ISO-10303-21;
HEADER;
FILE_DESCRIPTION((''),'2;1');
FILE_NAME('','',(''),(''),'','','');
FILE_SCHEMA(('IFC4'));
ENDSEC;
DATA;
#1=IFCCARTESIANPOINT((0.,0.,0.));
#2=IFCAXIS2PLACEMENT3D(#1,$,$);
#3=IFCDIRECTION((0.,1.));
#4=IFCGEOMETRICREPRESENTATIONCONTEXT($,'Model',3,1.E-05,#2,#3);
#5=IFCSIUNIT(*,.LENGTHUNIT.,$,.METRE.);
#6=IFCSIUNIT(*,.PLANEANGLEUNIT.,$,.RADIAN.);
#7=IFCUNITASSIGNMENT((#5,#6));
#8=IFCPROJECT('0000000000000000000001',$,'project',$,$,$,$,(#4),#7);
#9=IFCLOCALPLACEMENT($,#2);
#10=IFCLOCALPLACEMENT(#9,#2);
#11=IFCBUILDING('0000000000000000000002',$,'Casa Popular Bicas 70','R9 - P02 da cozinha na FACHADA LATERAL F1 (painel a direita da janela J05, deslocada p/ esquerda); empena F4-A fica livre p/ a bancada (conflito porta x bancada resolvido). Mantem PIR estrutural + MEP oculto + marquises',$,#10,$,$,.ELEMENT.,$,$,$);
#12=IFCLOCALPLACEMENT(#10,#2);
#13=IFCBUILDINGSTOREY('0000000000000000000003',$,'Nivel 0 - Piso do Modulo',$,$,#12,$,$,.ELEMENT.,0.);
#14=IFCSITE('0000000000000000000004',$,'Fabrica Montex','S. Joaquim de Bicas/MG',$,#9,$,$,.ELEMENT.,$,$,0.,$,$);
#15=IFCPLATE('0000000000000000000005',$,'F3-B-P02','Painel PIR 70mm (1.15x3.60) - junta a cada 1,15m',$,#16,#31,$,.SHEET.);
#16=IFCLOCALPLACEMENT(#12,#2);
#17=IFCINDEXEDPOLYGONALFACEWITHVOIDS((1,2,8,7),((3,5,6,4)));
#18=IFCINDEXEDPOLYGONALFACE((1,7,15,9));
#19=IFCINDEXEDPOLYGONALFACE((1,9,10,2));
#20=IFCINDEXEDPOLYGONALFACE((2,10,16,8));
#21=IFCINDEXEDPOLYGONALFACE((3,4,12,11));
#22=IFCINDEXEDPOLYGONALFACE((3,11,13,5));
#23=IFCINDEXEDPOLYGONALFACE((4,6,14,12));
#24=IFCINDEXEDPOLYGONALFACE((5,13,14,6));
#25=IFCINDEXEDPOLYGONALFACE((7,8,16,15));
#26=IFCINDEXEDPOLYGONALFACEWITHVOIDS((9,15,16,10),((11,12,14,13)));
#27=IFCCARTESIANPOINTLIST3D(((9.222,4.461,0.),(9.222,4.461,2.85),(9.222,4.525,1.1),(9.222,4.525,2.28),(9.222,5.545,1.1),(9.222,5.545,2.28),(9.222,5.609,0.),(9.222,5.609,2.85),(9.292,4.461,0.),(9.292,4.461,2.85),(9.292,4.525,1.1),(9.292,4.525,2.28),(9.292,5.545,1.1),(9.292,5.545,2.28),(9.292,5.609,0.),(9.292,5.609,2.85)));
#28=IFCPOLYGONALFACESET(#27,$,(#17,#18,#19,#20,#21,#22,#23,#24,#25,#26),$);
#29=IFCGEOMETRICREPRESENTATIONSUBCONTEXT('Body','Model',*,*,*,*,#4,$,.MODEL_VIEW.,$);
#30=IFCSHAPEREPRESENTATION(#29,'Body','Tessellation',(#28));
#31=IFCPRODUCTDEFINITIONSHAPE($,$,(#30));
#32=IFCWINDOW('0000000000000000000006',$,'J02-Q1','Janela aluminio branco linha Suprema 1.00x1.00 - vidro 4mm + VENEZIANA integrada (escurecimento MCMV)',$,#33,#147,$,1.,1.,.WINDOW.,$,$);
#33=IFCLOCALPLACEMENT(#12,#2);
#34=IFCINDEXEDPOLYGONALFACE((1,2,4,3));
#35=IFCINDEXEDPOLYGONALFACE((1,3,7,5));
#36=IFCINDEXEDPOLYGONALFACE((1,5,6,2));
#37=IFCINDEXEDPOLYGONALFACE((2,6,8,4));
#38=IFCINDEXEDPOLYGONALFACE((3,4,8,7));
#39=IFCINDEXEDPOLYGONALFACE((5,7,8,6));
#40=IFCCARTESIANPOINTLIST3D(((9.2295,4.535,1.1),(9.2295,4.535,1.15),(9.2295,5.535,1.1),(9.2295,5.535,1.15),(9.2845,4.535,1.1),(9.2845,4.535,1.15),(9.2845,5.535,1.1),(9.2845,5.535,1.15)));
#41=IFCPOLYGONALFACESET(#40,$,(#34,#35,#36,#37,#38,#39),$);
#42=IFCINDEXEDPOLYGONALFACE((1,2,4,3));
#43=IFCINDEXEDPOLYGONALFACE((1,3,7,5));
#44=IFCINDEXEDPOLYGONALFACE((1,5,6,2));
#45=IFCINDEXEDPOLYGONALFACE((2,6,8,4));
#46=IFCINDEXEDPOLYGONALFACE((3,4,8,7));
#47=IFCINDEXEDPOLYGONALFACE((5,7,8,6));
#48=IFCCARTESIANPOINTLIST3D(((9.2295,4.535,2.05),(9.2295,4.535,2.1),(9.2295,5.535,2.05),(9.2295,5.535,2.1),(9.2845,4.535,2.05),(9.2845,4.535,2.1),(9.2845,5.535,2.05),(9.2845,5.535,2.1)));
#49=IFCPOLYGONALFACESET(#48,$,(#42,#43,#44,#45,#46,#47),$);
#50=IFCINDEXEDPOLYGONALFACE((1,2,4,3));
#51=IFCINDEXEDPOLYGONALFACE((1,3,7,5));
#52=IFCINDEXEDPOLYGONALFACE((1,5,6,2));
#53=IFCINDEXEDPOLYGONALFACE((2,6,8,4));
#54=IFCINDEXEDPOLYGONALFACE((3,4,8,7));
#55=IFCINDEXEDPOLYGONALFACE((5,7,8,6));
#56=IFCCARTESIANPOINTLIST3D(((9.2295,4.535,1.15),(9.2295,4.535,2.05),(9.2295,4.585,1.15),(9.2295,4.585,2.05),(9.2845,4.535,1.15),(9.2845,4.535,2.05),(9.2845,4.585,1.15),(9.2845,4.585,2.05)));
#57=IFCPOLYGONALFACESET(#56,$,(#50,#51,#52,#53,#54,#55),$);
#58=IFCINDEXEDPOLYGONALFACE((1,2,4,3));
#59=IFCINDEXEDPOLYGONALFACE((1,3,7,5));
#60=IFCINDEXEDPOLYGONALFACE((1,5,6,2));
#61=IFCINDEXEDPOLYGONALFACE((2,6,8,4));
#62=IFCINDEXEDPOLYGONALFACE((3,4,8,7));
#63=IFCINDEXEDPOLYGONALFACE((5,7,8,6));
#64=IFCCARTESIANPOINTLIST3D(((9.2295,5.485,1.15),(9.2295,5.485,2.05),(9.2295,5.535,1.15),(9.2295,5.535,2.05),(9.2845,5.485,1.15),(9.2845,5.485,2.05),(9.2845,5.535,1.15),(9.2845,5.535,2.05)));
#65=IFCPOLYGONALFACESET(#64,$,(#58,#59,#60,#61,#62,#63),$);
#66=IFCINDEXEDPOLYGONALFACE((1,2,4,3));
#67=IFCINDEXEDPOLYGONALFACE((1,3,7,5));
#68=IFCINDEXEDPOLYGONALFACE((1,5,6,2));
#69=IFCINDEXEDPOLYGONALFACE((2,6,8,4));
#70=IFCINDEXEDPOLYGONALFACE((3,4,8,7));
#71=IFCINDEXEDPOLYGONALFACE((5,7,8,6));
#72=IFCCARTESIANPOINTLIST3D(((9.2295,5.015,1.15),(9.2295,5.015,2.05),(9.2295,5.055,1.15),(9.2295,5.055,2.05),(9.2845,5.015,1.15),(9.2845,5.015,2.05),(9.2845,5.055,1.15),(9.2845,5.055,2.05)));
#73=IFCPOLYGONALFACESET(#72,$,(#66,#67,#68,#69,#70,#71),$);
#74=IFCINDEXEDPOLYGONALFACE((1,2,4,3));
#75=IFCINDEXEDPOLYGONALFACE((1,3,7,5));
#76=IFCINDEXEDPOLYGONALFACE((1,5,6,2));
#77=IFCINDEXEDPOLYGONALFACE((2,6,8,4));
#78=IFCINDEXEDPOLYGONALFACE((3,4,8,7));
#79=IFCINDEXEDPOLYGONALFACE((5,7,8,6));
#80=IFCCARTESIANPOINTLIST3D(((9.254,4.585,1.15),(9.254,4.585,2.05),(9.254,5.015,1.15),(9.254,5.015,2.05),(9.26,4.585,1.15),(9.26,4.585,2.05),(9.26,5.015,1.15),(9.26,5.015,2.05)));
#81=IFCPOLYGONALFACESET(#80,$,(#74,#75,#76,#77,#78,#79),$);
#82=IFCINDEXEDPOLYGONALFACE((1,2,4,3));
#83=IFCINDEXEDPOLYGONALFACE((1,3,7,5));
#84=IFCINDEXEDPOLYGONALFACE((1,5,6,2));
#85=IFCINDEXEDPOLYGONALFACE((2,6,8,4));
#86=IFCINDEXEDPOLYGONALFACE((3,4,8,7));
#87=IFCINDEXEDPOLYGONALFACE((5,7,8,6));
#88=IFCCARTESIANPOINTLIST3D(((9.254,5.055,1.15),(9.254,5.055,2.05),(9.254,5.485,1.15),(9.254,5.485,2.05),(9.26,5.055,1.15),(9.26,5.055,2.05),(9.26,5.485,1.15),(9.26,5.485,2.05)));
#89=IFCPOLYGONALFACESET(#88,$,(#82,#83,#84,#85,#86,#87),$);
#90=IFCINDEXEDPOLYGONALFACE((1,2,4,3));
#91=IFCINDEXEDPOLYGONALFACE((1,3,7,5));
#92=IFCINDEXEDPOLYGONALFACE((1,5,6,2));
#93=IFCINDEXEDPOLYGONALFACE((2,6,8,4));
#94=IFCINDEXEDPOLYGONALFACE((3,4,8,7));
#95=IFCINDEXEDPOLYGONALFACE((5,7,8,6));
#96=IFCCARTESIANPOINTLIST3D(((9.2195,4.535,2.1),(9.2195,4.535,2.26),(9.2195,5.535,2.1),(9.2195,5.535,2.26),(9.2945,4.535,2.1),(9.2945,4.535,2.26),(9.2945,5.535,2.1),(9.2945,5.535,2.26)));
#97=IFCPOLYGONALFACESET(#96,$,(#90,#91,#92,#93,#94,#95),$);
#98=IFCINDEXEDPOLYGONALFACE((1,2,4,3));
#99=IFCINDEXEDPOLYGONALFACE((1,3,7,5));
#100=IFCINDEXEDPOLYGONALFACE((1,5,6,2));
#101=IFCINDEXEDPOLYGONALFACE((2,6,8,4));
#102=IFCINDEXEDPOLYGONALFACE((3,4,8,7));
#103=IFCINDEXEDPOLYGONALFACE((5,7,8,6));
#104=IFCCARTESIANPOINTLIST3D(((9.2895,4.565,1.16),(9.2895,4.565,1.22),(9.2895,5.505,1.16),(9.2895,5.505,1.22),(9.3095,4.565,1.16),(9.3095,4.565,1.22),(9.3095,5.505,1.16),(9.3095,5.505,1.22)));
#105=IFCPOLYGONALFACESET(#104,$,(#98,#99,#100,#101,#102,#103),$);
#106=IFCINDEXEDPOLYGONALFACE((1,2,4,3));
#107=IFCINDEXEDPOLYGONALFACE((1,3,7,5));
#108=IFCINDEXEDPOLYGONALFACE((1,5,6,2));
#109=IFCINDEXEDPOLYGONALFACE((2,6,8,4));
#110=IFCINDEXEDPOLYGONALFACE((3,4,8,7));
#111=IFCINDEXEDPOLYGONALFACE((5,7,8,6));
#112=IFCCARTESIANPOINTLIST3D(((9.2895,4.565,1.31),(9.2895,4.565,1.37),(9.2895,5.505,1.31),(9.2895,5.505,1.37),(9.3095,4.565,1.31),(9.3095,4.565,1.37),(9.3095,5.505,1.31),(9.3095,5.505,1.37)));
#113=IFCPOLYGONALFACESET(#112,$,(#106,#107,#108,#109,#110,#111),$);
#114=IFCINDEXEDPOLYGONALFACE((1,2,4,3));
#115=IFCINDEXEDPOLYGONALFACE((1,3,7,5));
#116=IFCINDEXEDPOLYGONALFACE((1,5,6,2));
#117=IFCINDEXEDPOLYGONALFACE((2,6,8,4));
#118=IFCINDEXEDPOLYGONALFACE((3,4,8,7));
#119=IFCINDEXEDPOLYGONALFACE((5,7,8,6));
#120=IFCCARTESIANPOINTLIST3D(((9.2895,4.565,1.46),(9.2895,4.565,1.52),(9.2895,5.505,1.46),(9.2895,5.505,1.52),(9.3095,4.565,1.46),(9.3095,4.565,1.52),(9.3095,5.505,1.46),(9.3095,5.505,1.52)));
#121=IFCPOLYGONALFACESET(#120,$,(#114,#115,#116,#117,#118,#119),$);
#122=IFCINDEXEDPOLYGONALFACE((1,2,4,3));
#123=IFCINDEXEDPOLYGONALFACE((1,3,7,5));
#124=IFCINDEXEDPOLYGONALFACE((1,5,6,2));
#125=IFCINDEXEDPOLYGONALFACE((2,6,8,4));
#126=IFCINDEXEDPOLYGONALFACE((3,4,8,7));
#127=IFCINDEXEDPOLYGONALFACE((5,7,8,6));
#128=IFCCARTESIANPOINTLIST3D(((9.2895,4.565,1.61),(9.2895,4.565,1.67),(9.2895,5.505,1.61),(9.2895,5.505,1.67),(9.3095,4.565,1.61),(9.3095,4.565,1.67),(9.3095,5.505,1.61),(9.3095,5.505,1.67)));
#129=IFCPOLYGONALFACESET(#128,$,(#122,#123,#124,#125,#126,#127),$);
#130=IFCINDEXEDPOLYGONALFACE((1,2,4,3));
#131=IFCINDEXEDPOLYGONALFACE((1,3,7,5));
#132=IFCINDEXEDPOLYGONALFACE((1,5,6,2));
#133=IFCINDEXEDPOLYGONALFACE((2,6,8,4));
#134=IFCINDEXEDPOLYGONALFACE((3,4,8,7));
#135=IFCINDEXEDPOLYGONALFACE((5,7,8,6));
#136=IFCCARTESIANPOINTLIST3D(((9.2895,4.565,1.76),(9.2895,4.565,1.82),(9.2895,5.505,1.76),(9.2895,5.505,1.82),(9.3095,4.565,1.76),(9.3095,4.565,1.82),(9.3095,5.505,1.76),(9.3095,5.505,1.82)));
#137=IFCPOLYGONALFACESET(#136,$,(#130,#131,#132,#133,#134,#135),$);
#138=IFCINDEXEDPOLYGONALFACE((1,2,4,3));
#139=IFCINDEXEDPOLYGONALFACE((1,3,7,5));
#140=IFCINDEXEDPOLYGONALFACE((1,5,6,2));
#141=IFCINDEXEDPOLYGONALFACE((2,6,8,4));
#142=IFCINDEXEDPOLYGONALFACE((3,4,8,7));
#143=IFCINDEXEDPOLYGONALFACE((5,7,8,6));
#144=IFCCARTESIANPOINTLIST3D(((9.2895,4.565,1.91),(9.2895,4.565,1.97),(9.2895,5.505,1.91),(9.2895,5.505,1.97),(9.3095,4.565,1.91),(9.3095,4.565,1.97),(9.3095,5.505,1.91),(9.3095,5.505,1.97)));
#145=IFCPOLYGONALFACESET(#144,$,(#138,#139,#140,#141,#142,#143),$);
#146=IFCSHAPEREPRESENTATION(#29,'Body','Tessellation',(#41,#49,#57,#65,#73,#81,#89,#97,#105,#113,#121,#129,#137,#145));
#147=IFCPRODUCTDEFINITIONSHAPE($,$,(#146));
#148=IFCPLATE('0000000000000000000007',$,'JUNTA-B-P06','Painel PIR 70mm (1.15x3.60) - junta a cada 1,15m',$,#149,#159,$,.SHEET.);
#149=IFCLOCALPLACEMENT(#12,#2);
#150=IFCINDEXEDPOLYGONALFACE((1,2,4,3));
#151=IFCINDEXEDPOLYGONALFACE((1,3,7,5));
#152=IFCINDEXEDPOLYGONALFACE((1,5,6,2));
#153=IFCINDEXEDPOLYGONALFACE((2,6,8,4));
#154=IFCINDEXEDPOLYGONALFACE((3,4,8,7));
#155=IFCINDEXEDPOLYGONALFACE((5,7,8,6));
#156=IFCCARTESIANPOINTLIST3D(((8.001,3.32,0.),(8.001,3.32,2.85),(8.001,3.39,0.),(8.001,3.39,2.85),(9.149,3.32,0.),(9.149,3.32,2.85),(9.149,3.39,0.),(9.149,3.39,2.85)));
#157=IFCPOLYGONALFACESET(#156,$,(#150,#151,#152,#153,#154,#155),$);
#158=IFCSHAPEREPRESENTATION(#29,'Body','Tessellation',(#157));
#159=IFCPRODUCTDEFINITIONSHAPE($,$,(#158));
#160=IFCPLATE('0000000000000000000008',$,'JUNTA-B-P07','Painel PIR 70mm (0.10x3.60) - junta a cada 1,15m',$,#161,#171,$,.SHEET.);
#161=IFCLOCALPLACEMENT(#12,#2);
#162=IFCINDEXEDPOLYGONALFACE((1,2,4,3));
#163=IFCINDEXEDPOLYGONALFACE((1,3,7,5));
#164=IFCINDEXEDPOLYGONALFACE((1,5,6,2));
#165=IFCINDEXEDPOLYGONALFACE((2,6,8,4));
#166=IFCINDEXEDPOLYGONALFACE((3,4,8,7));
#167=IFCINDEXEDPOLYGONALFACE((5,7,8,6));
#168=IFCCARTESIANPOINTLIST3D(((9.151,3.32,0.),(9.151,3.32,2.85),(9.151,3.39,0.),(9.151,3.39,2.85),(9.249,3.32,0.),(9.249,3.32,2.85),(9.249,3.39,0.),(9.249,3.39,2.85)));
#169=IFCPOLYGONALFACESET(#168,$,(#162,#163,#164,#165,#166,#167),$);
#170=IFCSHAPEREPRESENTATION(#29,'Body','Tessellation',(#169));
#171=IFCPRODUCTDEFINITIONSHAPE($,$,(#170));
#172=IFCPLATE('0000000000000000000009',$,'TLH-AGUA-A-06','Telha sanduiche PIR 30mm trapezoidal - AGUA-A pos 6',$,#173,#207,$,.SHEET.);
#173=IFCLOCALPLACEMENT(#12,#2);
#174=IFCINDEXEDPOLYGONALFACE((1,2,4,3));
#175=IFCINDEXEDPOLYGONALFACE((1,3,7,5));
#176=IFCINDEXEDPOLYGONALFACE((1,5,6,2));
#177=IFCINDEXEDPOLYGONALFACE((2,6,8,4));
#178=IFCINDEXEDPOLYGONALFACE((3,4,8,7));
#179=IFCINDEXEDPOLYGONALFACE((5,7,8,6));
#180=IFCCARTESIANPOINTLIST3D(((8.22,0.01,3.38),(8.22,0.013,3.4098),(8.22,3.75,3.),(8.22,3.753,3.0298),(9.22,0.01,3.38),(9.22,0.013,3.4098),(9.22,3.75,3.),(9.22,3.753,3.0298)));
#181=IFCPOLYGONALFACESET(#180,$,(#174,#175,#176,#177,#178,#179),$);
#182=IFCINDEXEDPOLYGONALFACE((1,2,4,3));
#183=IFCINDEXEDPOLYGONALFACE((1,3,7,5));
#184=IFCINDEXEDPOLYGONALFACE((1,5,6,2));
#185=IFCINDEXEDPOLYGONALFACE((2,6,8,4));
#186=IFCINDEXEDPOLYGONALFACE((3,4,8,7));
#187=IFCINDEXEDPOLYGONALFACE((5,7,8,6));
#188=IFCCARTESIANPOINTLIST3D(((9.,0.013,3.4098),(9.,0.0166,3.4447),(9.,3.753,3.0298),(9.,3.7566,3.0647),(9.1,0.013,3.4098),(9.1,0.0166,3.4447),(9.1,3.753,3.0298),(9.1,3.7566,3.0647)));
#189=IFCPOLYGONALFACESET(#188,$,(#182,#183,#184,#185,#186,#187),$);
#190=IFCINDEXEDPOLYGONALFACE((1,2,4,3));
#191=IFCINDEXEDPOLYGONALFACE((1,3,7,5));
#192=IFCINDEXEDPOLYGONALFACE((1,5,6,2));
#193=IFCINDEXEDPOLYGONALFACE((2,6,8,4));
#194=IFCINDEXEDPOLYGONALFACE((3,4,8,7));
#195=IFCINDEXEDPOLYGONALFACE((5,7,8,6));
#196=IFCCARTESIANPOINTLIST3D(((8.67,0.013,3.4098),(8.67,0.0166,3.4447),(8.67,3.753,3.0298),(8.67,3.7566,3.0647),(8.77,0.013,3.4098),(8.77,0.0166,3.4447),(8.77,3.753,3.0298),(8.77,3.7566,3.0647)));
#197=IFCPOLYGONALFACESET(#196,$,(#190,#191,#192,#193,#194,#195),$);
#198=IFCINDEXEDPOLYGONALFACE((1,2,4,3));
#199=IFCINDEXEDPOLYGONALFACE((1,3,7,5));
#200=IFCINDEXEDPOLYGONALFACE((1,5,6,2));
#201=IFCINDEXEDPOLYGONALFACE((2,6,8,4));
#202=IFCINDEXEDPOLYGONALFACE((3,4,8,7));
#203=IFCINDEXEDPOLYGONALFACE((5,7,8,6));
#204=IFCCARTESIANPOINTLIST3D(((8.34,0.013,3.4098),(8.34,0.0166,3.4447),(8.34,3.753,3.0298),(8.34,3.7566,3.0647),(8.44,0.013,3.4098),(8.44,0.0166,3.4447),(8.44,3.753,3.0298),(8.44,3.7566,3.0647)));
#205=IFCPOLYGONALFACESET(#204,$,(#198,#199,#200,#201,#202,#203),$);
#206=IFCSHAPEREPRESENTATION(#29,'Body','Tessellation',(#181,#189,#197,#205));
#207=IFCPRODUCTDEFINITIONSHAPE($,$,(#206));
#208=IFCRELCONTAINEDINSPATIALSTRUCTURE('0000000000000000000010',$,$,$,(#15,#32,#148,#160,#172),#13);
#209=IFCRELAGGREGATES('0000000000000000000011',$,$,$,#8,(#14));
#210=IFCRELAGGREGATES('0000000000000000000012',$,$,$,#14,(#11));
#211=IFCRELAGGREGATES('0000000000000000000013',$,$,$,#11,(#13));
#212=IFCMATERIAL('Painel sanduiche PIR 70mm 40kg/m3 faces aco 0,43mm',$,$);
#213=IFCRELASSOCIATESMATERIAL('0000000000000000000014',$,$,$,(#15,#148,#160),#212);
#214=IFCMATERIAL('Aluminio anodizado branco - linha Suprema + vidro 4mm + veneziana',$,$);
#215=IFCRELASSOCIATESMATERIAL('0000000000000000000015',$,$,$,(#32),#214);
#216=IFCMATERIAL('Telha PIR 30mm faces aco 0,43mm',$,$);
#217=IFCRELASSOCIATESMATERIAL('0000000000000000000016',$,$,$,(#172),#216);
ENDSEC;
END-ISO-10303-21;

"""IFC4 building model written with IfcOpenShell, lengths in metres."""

from ifc_helpers import new_model, si_unit, direction, frame, frame_2d, origin, place, context, subcontext, project, spatial, rectangle, extrude, material, element, fill, save


model = new_model("IFC4")

# Units and contexts
model_context = context("Model", 3, precision=1e-05, world=origin(), true_north=direction((0.0, 1.0)))
body_context = subcontext(model_context, "Body", "Model", "MODEL_VIEW")
ifc_project = project(units=[si_unit("LENGTHUNIT", "METRE"), si_unit("PLANEANGLEUNIT", "RADIAN")], contexts=[model_context])

# Site, building, storey
site_placement = place(None, origin())
site = spatial("IfcSite", under=ifc_project, at=site_placement, Name="Fabrica Montex", Description="S. Joaquim de Bicas/MG", CompositionType="ELEMENT", RefElevation=0.0)
building_placement = place(site_placement, origin())
building = spatial("IfcBuilding", under=site, at=building_placement, Name="Casa Popular Bicas 70", Description="R9 - P02 da cozinha na FACHADA LATERAL F1 (painel a direita da janela J05, deslocada p/ esquerda); empena F4-A fica livre p/ a bancada (conflito porta x bancada resolvido). Mantem PIR estrutural + MEP oculto + marquises", CompositionType="ELEMENT")
storey_placement = place(building_placement, origin())
storey = spatial("IfcBuildingStorey", under=building, at=storey_placement, Name="Nivel 0 - Piso do Modulo", CompositionType="ELEMENT", Elevation=0.0)

# Shared definitions
ifc_material_1 = material(Name="Painel sanduiche PIR 70mm 40kg/m3 faces aco 0,43mm")

# Plate, opening, window
plate_1_placement = place(storey_placement, frame((9.257, 4.461, 0.0), x_axis=(0.0, 1.0, 0.0)))
plate_1 = element("IfcPlate", 1, at=plate_1_placement, inside=storey, material=ifc_material_1, Name="F3-B-P02", Description="Painel PIR 70mm (1.15x3.60) - junta a cada 1,15m", PredefinedType="SHEET", context=body_context, shape_type="SweptSolid", body=[
    extrude(rectangle(XDim=1.148, YDim=0.07, at=frame_2d((0.574, 0.0))), origin(), (0.0, 0.0, 1.0), 2.85),
])
opening_1_placement = place(storey_placement, frame((9.257, 4.535, 1.1), x_axis=(0.0, 1.0, 0.0)))
opening_1 = element("IfcOpeningElement", 2, at=opening_1_placement, cuts=plate_1, PredefinedType="OPENING", context=body_context, shape_type="SweptSolid", body=[
    extrude(rectangle(XDim=1.02, YDim=0.3, at=frame_2d((0.5, 0.0))), origin(), (0.0, 0.0, 1.0), 1.18),
])
ifc_material_2 = material(Name="Aluminio anodizado branco - linha Suprema + vidro 4mm + veneziana")
window_placement = place(storey_placement, frame((9.257, 4.535, 1.1), x_axis=(0.0, 1.0, 0.0)))
window = element("IfcWindow", 3, at=window_placement, inside=storey, material=ifc_material_2, Name="J02-Q1", Description="Janela aluminio branco linha Suprema 1.00x1.00 - vidro 4mm + VENEZIANA integrada (escurecimento MCMV)", OverallHeight=1.0, OverallWidth=1.0, PredefinedType="WINDOW", context=body_context, shape_type="SweptSolid", body=[
    extrude(rectangle(XDim=1.0, YDim=0.055, at=frame_2d((0.5, 0.0))), origin(), (0.0, 0.0, 1.0), 0.05),
    extrude(rectangle(XDim=1.0, YDim=0.055, at=frame_2d((0.5, 0.0))), frame((0.0, 0.0, 0.95)), (0.0, 0.0, 1.0), 0.05),
    extrude(rectangle(XDim=0.05, YDim=0.055, at=frame_2d((0.025, 0.0))), frame((0.0, 0.0, 0.05)), (0.0, 0.0, 1.0), 0.9),
    extrude(rectangle(XDim=0.05, YDim=0.055, at=frame_2d((0.975, 0.0))), frame((0.0, 0.0, 0.05)), (0.0, 0.0, 1.0), 0.9),
    extrude(rectangle(XDim=0.04, YDim=0.055, at=frame_2d((0.5, 0.0))), frame((0.0, 0.0, 0.05)), (0.0, 0.0, 1.0), 0.9),
    extrude(rectangle(XDim=0.43, YDim=0.006, at=frame_2d((0.265, 0.0))), frame((0.0, 0.0, 0.05)), (0.0, 0.0, 1.0), 0.9),
    extrude(rectangle(XDim=0.43, YDim=0.006, at=frame_2d((0.735, 0.0))), frame((0.0, 0.0, 0.05)), (0.0, 0.0, 1.0), 0.9),
    extrude(rectangle(XDim=1.0, YDim=0.075, at=frame_2d((0.5, 0.0))), frame((0.0, 0.0, 1.0)), (0.0, 0.0, 1.0), 0.16),
    extrude(rectangle(XDim=0.94, YDim=0.02, at=frame_2d((0.5, -0.0425))), frame((0.0, 0.0, 0.06)), (0.0, 0.0, 1.0), 0.06),
    extrude(rectangle(XDim=0.94, YDim=0.02, at=frame_2d((0.5, -0.0425))), frame((0.0, 0.0, 0.21)), (0.0, 0.0, 1.0), 0.06),
    extrude(rectangle(XDim=0.94, YDim=0.02, at=frame_2d((0.5, -0.0425))), frame((0.0, 0.0, 0.36)), (0.0, 0.0, 1.0), 0.06),
    extrude(rectangle(XDim=0.94, YDim=0.02, at=frame_2d((0.5, -0.0425))), frame((0.0, 0.0, 0.51)), (0.0, 0.0, 1.0), 0.06),
    extrude(rectangle(XDim=0.94, YDim=0.02, at=frame_2d((0.5, -0.0425))), frame((0.0, 0.0, 0.66)), (0.0, 0.0, 1.0), 0.06),
    extrude(rectangle(XDim=0.94, YDim=0.02, at=frame_2d((0.5, -0.0425))), frame((0.0, 0.0, 0.81)), (0.0, 0.0, 1.0), 0.06),
])
fill(opening_1, window)

# Plates
plate_2_placement = place(storey_placement, frame((8.001, 3.355, 0.0), x_axis=(1.0, 0.0, 0.0)))
element("IfcPlate", 4, at=plate_2_placement, inside=storey, material=ifc_material_1, Name="JUNTA-B-P06", Description="Painel PIR 70mm (1.15x3.60) - junta a cada 1,15m", PredefinedType="SHEET", context=body_context, shape_type="SweptSolid", body=[
    extrude(rectangle(XDim=1.148, YDim=0.07, at=frame_2d((0.574, 0.0))), origin(), (0.0, 0.0, 1.0), 2.85),
])
plate_3_placement = place(storey_placement, frame((9.151, 3.355, 0.0), x_axis=(1.0, 0.0, 0.0)))
element("IfcPlate", 5, at=plate_3_placement, inside=storey, material=ifc_material_1, Name="JUNTA-B-P07", Description="Painel PIR 70mm (0.10x3.60) - junta a cada 1,15m", PredefinedType="SHEET", context=body_context, shape_type="SweptSolid", body=[
    extrude(rectangle(XDim=0.098, YDim=0.07, at=frame_2d((0.049, 0.0))), origin(), (0.0, 0.0, 1.0), 2.85),
])
ifc_material_3 = material(Name="Telha PIR 30mm faces aco 0,43mm")
for number, where, z_axis, x_axis, name in (
    (6, (9.22, 3.75, 3.0), (0.0, 0.101084, 0.994878), (-1.0, 0.0, 0.0), "TLH-AGUA-A-06"),
):
    element("IfcPlate", number, at=place(None, frame(where, z_axis=z_axis, x_axis=x_axis)), inside=storey, material=ifc_material_3, Name=name, Description="Telha sanduiche PIR 30mm trapezoidal - AGUA-A pos 6", PredefinedType="SHEET", context=body_context, shape_type="SweptSolid", body=[
        extrude(rectangle(XDim=1.0, YDim=3.7593, at=frame_2d((0.5, 1.8796))), origin(), (0.0, 0.0, 1.0), 0.03),
        extrude(rectangle(XDim=0.1, YDim=3.7593, at=frame_2d((0.17, 1.8796))), frame((0.0, 0.0, 0.03)), (0.0, 0.0, 1.0), 0.035),
        extrude(rectangle(XDim=0.1, YDim=3.7593, at=frame_2d((0.5, 1.8796))), frame((0.0, 0.0, 0.03)), (0.0, 0.0, 1.0), 0.035),
        extrude(rectangle(XDim=0.1, YDim=3.7593, at=frame_2d((0.83, 1.8796))), frame((0.0, 0.0, 0.03)), (0.0, 0.0, 1.0), 0.035),
    ])

save(model, "model.ifc")
